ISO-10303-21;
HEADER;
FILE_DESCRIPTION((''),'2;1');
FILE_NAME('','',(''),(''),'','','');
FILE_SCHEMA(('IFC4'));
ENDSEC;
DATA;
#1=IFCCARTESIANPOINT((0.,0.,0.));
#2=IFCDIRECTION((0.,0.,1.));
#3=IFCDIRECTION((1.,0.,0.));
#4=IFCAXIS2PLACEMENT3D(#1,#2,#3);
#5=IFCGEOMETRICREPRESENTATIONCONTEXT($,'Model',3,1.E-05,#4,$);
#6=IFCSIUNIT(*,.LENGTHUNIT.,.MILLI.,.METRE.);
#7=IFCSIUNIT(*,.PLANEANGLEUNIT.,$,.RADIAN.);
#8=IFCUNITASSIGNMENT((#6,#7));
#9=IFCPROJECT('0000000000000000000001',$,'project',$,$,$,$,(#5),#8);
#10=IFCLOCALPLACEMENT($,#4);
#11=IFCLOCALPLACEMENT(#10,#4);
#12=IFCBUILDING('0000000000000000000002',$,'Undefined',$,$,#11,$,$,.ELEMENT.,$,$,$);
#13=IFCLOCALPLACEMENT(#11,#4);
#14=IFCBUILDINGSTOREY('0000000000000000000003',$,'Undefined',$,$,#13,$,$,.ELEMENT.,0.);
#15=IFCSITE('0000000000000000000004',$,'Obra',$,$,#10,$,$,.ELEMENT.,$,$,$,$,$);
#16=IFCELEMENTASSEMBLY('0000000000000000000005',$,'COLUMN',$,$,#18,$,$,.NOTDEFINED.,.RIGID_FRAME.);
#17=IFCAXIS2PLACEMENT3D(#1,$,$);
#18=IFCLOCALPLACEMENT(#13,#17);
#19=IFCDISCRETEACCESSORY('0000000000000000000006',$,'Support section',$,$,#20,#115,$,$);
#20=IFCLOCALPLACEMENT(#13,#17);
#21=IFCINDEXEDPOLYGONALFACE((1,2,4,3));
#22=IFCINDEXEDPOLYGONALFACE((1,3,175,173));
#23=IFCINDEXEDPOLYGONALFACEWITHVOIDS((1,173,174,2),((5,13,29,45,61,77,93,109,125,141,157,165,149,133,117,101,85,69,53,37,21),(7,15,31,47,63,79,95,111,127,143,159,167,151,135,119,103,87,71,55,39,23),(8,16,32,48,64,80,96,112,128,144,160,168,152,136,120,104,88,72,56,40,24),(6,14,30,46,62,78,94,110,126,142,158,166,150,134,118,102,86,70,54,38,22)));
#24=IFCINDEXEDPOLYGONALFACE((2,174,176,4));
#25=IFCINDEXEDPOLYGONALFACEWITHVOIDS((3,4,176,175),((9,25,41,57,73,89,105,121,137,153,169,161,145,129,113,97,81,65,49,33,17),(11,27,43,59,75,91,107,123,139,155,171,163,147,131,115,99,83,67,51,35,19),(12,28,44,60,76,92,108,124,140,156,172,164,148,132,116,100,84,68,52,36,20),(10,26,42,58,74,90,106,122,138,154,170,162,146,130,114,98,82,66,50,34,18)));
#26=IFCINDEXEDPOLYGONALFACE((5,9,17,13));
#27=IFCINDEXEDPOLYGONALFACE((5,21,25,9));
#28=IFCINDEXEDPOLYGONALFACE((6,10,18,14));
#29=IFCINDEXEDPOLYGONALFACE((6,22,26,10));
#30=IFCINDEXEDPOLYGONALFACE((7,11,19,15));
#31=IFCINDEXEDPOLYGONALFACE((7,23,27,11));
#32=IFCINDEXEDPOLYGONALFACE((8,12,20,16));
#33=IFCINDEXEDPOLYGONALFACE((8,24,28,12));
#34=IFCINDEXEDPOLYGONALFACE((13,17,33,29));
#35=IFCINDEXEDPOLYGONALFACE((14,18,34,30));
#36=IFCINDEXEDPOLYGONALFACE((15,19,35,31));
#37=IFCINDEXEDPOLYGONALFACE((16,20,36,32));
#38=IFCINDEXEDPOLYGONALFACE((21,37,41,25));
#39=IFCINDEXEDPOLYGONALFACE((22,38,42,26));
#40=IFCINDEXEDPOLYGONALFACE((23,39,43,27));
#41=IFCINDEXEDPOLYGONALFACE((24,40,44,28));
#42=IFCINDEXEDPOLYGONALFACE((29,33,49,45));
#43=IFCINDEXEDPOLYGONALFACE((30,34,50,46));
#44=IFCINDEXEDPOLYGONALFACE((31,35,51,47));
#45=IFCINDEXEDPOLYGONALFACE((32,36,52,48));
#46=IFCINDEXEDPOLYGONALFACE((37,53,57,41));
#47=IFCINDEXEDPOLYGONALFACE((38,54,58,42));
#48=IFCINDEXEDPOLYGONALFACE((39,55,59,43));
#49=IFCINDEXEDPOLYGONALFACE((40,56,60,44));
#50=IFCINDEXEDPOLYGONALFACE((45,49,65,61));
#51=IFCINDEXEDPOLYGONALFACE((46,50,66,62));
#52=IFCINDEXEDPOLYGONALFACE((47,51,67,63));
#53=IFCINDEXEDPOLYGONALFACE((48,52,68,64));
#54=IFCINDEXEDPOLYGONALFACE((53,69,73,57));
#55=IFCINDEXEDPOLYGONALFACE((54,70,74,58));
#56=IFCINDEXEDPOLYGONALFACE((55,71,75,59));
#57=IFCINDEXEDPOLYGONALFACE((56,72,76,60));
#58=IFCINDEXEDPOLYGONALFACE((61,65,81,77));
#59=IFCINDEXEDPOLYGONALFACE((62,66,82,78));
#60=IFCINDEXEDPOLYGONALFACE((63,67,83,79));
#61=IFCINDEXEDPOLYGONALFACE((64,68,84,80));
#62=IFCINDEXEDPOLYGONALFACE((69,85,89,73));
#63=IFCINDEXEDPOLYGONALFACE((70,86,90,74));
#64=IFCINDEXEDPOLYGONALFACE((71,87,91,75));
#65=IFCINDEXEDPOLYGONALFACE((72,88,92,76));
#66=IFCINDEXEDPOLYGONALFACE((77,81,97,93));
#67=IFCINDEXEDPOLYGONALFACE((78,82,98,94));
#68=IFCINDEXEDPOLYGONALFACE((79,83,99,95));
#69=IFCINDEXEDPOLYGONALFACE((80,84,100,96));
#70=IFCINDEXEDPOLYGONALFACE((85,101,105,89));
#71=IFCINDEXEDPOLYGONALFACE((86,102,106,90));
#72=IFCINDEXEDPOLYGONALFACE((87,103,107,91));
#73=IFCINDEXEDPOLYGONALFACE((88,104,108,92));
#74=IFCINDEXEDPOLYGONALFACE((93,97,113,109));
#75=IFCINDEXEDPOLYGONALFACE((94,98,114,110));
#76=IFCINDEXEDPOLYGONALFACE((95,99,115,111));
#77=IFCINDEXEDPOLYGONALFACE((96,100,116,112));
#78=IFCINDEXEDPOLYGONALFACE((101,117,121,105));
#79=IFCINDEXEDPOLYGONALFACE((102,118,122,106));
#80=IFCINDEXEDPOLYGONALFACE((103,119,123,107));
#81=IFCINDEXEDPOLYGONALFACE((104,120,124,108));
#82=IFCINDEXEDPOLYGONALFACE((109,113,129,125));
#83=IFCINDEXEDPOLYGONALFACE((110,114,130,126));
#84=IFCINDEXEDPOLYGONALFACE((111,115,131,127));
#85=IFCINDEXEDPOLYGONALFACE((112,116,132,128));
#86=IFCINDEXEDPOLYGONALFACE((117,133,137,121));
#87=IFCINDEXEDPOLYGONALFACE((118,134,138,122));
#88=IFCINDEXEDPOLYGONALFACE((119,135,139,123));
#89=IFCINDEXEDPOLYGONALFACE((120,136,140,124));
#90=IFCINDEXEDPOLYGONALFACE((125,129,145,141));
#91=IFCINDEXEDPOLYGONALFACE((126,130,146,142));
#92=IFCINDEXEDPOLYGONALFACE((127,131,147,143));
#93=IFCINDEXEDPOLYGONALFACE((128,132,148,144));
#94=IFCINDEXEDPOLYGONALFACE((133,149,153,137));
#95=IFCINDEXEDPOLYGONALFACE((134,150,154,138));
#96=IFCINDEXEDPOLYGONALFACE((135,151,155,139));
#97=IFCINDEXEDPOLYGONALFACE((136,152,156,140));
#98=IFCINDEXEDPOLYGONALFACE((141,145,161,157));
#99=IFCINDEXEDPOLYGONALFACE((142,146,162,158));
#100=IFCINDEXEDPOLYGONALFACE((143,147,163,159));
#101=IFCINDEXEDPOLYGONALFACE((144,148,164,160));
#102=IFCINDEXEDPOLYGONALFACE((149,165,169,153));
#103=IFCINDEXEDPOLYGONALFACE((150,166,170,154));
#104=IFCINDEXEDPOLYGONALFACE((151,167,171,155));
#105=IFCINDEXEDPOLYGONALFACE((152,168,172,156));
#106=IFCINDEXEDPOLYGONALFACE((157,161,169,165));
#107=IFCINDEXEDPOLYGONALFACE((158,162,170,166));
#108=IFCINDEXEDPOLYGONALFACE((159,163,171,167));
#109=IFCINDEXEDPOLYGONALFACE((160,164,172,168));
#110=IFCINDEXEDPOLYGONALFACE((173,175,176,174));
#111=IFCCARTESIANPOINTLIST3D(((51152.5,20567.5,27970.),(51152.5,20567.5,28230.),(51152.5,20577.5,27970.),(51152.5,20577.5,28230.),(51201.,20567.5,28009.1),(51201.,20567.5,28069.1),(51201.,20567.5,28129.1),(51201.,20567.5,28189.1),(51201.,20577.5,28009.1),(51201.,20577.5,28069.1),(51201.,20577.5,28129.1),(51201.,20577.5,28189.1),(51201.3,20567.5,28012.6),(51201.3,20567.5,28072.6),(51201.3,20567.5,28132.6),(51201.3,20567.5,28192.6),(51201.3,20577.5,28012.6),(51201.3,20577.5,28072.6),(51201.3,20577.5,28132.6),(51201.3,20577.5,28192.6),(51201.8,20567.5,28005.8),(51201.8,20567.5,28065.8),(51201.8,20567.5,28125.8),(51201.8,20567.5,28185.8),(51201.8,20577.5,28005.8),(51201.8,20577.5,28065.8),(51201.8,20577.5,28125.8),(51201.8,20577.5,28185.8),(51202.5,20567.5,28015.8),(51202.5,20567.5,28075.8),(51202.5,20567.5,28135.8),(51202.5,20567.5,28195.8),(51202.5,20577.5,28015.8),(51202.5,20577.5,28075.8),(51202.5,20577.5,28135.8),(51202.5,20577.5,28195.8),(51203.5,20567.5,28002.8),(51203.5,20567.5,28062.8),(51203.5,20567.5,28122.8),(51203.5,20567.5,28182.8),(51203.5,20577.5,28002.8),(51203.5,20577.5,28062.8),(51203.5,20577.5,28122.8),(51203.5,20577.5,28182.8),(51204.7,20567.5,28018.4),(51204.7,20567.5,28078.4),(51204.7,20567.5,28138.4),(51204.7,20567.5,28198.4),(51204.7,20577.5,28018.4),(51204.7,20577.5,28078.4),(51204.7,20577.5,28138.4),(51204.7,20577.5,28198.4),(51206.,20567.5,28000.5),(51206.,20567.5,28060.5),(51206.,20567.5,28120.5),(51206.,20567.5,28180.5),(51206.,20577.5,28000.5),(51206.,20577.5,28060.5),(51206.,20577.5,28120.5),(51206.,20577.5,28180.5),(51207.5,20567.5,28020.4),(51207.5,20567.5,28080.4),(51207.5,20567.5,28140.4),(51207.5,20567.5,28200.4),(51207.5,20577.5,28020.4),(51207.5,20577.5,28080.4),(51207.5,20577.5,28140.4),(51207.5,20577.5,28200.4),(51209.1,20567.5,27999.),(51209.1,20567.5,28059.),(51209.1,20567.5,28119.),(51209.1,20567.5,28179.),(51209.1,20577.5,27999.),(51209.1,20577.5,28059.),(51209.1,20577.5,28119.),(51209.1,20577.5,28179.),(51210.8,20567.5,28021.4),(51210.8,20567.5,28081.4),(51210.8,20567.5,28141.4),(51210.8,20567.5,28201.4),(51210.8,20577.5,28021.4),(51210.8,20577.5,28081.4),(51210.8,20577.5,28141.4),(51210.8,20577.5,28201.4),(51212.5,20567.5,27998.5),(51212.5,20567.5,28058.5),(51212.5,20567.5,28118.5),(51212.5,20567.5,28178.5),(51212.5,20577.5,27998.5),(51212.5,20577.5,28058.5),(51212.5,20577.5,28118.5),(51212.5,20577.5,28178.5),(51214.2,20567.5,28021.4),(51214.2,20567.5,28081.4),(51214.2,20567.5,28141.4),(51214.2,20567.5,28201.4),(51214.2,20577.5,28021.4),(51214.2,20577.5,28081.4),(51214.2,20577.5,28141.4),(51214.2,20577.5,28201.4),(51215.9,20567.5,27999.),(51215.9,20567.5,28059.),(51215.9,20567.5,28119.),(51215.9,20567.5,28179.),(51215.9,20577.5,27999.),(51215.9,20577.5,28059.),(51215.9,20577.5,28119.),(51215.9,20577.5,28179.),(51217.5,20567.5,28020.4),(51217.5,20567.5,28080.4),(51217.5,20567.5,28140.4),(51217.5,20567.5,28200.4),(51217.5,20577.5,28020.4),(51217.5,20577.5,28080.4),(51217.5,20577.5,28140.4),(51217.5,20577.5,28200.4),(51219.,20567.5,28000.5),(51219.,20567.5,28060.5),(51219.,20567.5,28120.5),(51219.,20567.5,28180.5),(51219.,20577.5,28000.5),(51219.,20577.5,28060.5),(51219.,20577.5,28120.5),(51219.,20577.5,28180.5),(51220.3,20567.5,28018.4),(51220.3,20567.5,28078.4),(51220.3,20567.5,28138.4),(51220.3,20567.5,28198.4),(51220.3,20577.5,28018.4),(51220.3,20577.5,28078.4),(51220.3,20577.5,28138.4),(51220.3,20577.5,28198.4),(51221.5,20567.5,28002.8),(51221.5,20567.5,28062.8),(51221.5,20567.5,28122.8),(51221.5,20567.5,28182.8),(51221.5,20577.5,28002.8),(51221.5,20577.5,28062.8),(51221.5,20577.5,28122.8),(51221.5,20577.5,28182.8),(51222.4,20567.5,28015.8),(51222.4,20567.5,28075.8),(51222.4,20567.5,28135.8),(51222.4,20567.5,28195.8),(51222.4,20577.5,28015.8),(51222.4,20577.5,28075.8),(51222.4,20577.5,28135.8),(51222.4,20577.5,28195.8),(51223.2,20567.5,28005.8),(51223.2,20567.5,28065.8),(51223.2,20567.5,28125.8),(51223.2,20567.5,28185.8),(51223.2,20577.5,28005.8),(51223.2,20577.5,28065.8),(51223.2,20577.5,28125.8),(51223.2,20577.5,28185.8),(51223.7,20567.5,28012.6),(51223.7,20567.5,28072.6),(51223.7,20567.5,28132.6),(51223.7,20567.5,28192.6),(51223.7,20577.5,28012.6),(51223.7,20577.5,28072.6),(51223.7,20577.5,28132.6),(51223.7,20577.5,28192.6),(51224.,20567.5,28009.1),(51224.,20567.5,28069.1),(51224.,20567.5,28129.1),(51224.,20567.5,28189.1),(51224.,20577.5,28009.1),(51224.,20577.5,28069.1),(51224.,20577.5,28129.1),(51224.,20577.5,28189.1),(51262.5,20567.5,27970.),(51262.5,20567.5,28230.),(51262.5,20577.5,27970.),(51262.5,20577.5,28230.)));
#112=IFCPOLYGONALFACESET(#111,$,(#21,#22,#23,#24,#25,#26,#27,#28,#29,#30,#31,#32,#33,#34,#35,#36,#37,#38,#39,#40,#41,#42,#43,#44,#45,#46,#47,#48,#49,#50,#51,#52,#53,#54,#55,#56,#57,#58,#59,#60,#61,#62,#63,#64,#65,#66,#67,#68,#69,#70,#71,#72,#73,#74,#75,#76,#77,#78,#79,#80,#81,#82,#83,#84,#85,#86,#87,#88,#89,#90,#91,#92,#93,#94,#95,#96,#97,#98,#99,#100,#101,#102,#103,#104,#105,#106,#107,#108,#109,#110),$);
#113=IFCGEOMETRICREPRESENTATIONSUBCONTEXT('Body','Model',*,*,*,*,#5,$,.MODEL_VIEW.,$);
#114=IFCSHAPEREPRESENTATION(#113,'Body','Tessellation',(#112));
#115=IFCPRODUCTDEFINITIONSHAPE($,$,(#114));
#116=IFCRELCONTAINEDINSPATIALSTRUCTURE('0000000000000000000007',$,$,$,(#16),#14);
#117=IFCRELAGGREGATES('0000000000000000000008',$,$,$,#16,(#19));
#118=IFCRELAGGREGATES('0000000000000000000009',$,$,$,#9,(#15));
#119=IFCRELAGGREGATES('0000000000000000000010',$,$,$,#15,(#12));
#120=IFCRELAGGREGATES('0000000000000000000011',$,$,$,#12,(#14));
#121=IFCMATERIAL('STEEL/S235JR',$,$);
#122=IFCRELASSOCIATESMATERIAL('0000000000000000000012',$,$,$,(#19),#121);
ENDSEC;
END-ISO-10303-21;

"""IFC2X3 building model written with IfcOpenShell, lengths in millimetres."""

from ifc_helpers import new_model, si_unit, frame, origin_with_axes, origin_2d_with_axis, place, context, subcontext, project, spatial, rectangle, circle, extrude, source, transform, mapped, material, element, aggregate, save


model = new_model("IFC2X3")

# Units and contexts
model_context = context("Model", 3, precision=1e-05, world=origin_with_axes())
body_context = subcontext(model_context, "Body", "Model", "MODEL_VIEW")
ifc_project = project(units=[si_unit("LENGTHUNIT", "METRE", prefix="MILLI"), si_unit("PLANEANGLEUNIT", "RADIAN")], contexts=[model_context])

# Site, building, storey
site_placement = place(None, origin_with_axes())
site = spatial("IfcSite", under=ifc_project, at=site_placement, Name="Obra", CompositionType="ELEMENT")
building_placement = place(site_placement, origin_with_axes())
building = spatial("IfcBuilding", under=site, at=building_placement, Name="Undefined", CompositionType="ELEMENT")
storey_placement = place(building_placement, origin_with_axes())
storey = spatial("IfcBuildingStorey", under=building, at=storey_placement, Name="Undefined", CompositionType="ELEMENT", Elevation=0.0)

# Element assembly
ifc_material_1 = material(Name="STEEL/S235JR")
assembly_1_placement = place(storey_placement, origin_with_axes())
assembly_1 = element("IfcElementAssembly", 1, at=assembly_1_placement, inside=storey, Name="COLUMN", AssemblyPlace="NOTDEFINED", PredefinedType="RIGID_FRAME")

# Discrete accessory, opening
shared_shape_1 = source(origin_with_axes(), body_context, "Body", "SweptSolid", [
    extrude(circle(Radius=11.5, at=origin_2d_with_axis()), frame((0.0, -14.4, 0.0), z_axis=(0.0, 1.0, 0.0), x_axis=(1.0, 0.0, 0.0)), (0.0, 0.0, 1.0), 10.2),
])
discrete_accessory_1_placement = place(assembly_1_placement, frame((51207.5, 20572.5, 27970.0), z_axis=(0.0, 0.0, 1.0), x_axis=(-1.0, 0.0, 0.0)))
discrete_accessory_1 = element("IfcDiscreteAccessory", 2, at=discrete_accessory_1_placement, material=ifc_material_1, Name="Support section", context=body_context, shape_type="SweptSolid", body=[
    extrude(rectangle(XDim=10.0, YDim=110.0, at=origin_2d_with_axis()), frame((0.0, 0.0, 260.0), z_axis=(0.0, 0.0, -1.0), x_axis=(0.0, 1.0, 0.0)), (0.0, 0.0, 1.0), 260.0),
])
opening_1_placement = place(assembly_1_placement, frame((51162.5, 20581.8, 28300.0), z_axis=(1.0, 0.0, 0.0), x_axis=(0.0, 0.0, -1.0)))
element("IfcOpeningElement", 3, at=opening_1_placement, cuts=discrete_accessory_1, ObjectType="Opening", context=body_context, shape_type="MappedRepresentation", body=[
    mapped(shared_shape_1, transform((110.0, 0.0, 50.0))),
    mapped(shared_shape_1, transform((170.0, 0.0, 50.0))),
    mapped(shared_shape_1, transform((230.0, 0.0, 50.0))),
    mapped(shared_shape_1, transform((290.0, 0.0, 50.0))),
])
aggregate(assembly_1, [discrete_accessory_1])

save(model, "model.ifc")
